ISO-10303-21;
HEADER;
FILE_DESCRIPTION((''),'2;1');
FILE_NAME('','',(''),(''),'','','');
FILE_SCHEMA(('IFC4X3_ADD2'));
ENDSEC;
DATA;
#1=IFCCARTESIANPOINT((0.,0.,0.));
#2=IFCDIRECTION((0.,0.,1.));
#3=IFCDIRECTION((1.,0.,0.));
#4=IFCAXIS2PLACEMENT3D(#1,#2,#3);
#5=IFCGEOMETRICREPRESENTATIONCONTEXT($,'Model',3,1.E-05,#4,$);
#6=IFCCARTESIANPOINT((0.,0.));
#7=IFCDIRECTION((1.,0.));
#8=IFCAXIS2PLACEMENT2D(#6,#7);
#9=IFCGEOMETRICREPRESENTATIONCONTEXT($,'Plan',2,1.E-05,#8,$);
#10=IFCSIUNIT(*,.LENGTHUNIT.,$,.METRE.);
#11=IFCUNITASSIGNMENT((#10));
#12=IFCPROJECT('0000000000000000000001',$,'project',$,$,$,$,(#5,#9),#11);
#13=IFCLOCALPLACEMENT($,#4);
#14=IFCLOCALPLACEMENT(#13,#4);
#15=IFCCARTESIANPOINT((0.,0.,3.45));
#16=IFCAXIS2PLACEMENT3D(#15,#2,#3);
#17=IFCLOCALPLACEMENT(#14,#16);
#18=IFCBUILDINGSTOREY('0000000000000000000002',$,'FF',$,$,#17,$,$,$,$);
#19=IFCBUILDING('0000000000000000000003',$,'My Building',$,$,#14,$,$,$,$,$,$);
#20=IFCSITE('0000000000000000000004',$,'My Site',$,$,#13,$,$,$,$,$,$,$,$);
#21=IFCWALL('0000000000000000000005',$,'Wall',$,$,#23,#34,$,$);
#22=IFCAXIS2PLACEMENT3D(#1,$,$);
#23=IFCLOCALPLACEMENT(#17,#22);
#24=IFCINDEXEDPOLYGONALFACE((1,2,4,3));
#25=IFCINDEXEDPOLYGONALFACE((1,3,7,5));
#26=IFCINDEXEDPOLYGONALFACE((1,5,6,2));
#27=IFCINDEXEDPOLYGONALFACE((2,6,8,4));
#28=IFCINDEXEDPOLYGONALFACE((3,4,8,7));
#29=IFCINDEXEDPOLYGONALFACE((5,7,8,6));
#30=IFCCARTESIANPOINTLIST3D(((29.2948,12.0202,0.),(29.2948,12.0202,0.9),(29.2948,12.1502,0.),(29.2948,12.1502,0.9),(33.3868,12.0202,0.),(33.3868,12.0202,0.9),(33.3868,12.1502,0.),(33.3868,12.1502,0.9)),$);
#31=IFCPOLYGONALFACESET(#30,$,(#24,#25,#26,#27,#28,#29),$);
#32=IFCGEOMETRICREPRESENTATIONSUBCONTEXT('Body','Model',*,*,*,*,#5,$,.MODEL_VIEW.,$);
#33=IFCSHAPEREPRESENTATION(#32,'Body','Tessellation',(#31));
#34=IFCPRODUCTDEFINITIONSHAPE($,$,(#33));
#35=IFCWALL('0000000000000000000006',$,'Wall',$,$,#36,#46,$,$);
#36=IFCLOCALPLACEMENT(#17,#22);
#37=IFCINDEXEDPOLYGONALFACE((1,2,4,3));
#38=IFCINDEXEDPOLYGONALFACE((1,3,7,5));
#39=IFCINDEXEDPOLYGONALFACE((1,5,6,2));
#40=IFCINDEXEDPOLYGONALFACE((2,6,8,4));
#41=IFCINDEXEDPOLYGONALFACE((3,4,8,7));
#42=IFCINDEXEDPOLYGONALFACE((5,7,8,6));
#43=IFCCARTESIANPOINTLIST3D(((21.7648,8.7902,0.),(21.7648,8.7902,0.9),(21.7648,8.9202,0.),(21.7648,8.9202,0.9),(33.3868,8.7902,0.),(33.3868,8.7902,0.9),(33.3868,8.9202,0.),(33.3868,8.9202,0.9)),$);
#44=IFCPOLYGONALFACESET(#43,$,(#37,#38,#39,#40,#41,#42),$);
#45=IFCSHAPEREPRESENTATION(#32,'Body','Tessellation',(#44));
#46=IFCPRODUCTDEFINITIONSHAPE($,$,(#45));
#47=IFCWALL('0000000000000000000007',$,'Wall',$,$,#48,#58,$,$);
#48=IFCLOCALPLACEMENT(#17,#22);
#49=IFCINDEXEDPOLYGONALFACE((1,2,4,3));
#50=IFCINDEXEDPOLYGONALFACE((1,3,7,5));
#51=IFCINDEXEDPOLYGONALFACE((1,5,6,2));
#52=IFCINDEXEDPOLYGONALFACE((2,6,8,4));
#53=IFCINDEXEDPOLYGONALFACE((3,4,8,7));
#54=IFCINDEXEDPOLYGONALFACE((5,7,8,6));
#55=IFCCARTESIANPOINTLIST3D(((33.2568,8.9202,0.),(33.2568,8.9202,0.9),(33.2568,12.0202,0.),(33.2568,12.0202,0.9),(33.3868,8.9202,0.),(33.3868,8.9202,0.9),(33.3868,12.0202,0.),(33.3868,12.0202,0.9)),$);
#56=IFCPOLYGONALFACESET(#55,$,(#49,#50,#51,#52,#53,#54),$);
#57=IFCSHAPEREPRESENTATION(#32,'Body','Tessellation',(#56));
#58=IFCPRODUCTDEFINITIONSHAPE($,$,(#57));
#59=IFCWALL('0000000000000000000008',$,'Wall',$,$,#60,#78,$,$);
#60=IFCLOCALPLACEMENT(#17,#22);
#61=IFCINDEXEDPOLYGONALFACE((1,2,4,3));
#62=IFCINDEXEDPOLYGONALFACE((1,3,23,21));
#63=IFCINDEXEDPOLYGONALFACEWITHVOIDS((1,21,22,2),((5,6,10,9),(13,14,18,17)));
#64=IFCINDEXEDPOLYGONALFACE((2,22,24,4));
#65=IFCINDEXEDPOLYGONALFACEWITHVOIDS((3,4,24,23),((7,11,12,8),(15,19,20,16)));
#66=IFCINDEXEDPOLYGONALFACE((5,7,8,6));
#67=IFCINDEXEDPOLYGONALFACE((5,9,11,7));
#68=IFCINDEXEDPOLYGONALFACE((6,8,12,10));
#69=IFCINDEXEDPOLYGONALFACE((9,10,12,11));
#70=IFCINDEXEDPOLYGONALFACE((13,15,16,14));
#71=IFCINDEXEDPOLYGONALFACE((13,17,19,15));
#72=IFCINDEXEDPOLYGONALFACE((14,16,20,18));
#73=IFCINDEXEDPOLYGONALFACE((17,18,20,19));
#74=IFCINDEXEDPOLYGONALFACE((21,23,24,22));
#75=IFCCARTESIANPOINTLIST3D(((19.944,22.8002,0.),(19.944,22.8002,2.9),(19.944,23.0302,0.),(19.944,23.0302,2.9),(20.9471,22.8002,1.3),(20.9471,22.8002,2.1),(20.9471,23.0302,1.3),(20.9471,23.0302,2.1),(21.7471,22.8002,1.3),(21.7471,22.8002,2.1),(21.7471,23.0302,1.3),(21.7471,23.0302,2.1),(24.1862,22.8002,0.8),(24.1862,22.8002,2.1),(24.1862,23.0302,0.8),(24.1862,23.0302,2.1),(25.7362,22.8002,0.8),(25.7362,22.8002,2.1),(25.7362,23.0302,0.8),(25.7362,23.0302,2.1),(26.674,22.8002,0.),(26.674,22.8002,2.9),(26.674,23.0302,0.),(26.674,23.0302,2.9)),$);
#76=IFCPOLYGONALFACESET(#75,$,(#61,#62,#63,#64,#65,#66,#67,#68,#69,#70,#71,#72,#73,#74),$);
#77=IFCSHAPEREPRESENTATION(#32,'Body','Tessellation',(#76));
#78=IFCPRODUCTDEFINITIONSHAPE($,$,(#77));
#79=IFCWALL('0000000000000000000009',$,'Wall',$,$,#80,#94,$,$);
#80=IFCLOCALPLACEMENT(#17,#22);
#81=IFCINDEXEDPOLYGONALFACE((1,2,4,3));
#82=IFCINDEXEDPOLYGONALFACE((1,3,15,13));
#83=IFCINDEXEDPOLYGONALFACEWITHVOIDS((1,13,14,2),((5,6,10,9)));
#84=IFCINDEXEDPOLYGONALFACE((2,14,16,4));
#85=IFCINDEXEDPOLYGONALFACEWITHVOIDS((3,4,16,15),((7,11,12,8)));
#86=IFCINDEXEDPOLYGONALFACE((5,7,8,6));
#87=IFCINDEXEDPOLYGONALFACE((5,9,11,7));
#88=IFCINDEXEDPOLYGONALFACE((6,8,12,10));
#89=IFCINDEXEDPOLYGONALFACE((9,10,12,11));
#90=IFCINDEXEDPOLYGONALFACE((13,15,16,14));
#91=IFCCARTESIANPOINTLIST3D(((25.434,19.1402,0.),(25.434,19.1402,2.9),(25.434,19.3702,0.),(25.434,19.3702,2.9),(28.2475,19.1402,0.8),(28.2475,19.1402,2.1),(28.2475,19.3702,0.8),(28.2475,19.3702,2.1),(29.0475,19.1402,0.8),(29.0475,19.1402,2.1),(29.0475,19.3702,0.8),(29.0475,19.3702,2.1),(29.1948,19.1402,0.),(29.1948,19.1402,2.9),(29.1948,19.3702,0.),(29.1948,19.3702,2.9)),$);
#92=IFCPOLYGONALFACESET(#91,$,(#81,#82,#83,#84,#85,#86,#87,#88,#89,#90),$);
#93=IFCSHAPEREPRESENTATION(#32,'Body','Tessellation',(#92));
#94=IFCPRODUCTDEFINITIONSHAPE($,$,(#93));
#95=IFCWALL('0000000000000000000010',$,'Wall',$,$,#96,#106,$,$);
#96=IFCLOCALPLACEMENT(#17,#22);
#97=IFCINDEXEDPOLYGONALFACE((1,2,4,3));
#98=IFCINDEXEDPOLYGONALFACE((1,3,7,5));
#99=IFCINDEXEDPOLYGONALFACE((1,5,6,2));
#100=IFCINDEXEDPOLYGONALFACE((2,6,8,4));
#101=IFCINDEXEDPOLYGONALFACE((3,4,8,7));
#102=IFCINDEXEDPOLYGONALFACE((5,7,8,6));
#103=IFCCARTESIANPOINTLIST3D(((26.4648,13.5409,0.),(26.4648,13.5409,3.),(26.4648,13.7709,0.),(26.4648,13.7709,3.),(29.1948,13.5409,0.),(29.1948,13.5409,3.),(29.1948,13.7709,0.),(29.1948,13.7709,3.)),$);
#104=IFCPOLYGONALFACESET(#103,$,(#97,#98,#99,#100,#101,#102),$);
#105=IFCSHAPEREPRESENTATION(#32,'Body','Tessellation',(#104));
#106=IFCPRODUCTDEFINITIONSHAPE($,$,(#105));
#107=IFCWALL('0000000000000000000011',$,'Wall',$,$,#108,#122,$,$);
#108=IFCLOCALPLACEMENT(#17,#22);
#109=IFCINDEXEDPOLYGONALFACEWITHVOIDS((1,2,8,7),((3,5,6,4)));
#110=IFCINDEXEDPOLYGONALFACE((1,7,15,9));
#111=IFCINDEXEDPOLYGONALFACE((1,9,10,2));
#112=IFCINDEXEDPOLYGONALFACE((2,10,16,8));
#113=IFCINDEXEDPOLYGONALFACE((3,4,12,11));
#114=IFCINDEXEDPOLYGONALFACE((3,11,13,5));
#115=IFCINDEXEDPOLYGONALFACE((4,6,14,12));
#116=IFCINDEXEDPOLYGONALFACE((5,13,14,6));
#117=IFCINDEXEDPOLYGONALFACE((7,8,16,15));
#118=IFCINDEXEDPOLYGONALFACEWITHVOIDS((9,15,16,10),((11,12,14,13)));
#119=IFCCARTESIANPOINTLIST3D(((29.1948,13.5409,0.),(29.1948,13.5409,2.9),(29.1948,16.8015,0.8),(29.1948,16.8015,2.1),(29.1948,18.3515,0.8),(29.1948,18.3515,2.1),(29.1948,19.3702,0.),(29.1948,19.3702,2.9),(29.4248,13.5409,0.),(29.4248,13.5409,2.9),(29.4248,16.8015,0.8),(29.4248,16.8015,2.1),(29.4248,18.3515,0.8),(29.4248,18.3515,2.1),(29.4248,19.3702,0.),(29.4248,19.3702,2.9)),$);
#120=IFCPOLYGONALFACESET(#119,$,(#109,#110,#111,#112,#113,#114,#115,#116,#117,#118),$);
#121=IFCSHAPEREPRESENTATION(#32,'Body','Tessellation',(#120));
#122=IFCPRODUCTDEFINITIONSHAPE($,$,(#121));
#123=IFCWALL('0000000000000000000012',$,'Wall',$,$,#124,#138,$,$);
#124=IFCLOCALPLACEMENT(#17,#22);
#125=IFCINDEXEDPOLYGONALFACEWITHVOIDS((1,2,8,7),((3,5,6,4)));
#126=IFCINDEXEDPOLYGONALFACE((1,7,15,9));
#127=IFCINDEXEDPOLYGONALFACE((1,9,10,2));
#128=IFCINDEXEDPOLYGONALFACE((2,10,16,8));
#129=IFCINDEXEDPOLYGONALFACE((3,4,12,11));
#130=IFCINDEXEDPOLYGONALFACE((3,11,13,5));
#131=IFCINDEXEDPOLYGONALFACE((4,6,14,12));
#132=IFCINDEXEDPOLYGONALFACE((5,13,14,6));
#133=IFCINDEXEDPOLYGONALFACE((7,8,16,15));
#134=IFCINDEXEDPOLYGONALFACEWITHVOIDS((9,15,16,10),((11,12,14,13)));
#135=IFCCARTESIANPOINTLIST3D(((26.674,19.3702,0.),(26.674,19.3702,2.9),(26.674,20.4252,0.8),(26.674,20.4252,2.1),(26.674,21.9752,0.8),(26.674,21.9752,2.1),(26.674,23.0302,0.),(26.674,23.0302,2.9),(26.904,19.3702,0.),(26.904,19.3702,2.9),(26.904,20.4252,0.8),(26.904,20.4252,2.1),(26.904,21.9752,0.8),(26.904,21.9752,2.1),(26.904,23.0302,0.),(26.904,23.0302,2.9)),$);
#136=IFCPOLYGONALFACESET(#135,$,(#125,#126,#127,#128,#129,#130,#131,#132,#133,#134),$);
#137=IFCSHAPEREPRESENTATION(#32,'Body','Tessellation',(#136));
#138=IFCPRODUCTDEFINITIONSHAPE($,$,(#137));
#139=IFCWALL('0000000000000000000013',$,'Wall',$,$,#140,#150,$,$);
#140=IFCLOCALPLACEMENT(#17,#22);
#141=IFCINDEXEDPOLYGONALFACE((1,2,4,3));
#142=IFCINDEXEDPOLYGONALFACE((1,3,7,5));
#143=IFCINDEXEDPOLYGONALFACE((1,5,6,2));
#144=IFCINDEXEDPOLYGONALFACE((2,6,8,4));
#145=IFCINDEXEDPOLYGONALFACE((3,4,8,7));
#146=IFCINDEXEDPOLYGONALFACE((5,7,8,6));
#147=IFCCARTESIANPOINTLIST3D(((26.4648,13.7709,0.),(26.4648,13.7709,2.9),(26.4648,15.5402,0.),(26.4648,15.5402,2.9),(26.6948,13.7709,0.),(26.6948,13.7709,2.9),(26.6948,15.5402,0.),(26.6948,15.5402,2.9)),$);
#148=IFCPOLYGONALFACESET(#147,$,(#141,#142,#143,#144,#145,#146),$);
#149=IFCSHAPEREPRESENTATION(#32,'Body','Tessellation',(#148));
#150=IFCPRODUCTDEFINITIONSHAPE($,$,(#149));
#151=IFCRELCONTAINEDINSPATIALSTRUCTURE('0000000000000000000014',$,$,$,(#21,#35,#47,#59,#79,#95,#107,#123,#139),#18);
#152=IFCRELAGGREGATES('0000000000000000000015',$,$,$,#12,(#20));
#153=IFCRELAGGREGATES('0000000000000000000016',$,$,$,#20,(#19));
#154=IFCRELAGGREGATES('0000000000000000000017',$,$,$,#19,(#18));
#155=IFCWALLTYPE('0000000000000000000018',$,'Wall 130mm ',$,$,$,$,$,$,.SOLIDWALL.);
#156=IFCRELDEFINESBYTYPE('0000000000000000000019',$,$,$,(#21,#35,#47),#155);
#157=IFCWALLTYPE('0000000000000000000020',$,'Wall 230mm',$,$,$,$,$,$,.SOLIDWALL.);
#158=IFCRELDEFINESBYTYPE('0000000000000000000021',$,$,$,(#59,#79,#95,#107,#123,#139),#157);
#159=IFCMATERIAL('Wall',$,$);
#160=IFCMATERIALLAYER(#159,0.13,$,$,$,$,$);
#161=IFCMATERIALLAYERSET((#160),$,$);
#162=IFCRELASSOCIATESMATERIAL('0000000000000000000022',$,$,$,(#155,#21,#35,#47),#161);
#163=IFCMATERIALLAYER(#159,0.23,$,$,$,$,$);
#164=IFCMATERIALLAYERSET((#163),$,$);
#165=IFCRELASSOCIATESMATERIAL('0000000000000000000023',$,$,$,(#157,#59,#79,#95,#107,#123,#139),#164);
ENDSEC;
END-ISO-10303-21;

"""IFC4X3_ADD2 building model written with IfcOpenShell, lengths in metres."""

from ifc_helpers import new_model, si_unit, frame, origin_with_axes, origin_2d_with_axis, place, context, subcontext, project, spatial, line, indexed_curve, outline, extrude, source, transform, mapped, material, layer, layer_set, layer_usage, type_object, element, save


model = new_model("IFC4X3_ADD2")

# Units and contexts
model_context = context("Model", 3, precision=1e-05, world=origin_with_axes())
plan_context = context("Plan", 2, precision=1e-05, world=origin_2d_with_axis())
body_context_1 = subcontext(model_context, "Body", "Model", "MODEL_VIEW")
ifc_project = project(units=[si_unit("LENGTHUNIT", "METRE")], contexts=[model_context, plan_context])

# Site, building, storey
site_placement = place(None, origin_with_axes())
site = spatial("IfcSite", under=ifc_project, at=site_placement, Name="My Site")
building_placement = place(site_placement, origin_with_axes())
building = spatial("IfcBuilding", under=site, at=building_placement, Name="My Building")
storey_placement = place(building_placement, frame((0.0, 0.0, 3.45), z_axis=(0.0, 0.0, 1.0), x_axis=(1.0, 0.0, 0.0)))
storey = spatial("IfcBuildingStorey", under=building, at=storey_placement, Name="FF")

# Walls
ifc_material_1 = material(Name="Wall")
ifc_layer_1 = layer(ifc_material_1, 0.13)
ifc_layer_set_1 = layer_set([ifc_layer_1])
ifc_layer_usage_1 = layer_usage(ifc_layer_set_1, "AXIS2", "POSITIVE", 0.0)
wall_type_1 = type_object("IfcWallType", Name="Wall 130mm ", PredefinedType="SOLIDWALL", material=ifc_layer_set_1)
wall_1_placement = place(storey_placement, frame((33.3868, 12.1502, 0.0), z_axis=(0.0, 0.0, 1.0), x_axis=(-1.0, 0.0, 0.0)))
element("IfcWall", 1, at=wall_1_placement, inside=storey, type_object=wall_type_1, material=ifc_layer_usage_1, Name="Wall", context=body_context_1, shape_type="SweptSolid", body=[
    extrude(outline(indexed_curve([(0.0, 0.0), (0.0, 0.13), (4.092, 0.13), (4.092, 0.0), (0.0, 0.0)], self_intersect=False)), origin_with_axes(), (0.0, 0.0, 1.0), 0.9),
])
ifc_layer_usage_2 = layer_usage(ifc_layer_set_1, "AXIS2", "POSITIVE", 0.0)
wall_2_placement = place(storey_placement, frame((33.3868, 8.9202, 0.0), z_axis=(0.0, 0.0, 1.0), x_axis=(-1.0, 0.0, 0.0)))
element("IfcWall", 2, at=wall_2_placement, inside=storey, type_object=wall_type_1, material=ifc_layer_usage_2, Name="Wall", context=body_context_1, shape_type="SweptSolid", body=[
    extrude(outline(indexed_curve([(0.0, 0.0), (0.0, 0.13), (11.622, 0.13), (11.622, 0.0), (0.0, 0.0)], self_intersect=False)), origin_with_axes(), (0.0, 0.0, 1.0), 0.9),
])
ifc_layer_usage_3 = layer_usage(ifc_layer_set_1, "AXIS2", "POSITIVE", 0.0)
wall_3_placement = place(storey_placement, frame((33.2568, 12.0202, 0.0), z_axis=(0.0, 0.0, 1.0), x_axis=(0.0, -1.0, 0.0)))
element("IfcWall", 3, at=wall_3_placement, inside=storey, type_object=wall_type_1, material=ifc_layer_usage_3, Name="Wall", context=body_context_1, shape_type="SweptSolid", body=[
    extrude(outline(indexed_curve([(0.0, 0.0), (0.0, 0.13), (3.1, 0.13), (3.1, 0.0), (0.0, 0.0)], self_intersect=False)), origin_with_axes(), (0.0, 0.0, 1.0), 0.9),
])

# Wall, openings
ifc_layer_2 = layer(ifc_material_1, 0.23)
ifc_layer_set_2 = layer_set([ifc_layer_2])
ifc_layer_usage_4 = layer_usage(ifc_layer_set_2, "AXIS2", "POSITIVE", 0.0)
wall_type_2 = type_object("IfcWallType", Name="Wall 230mm", PredefinedType="SOLIDWALL", material=ifc_layer_set_2)
wall_4_placement = place(storey_placement, frame((26.674, 23.0302, 0.0), z_axis=(0.0, 0.0, 1.0), x_axis=(-1.0, 0.0, 0.0)))
wall_4 = element("IfcWall", 4, at=wall_4_placement, inside=storey, type_object=wall_type_2, material=ifc_layer_usage_4, Name="Wall", context=body_context_1, shape_type="SweptSolid", body=[
    extrude(outline(indexed_curve([(0.0, 0.0), (0.0, 0.23), (6.73, 0.23), (6.73, 0.0), (0.0, 0.0)], self_intersect=False)), origin_with_axes(), (0.0, 0.0, 1.0), 2.9),
])
shared_shape_1 = source(origin_with_axes(), body_context_1, "Body", "SweptSolid", [
    extrude(outline(indexed_curve([(0.0, 0.0), (1.55, 0.0), (1.55, 1.3), (0.0, 1.3)], segments=[line(1, 2, 3, 4, 1)])), frame((-0.775, -0.6, 0.0), z_axis=(0.0, -1.0, 0.0), x_axis=(1.0, 0.0, 0.0)), (0.0, 0.0, -1.0), 1.2),
])
opening_1_placement = place(wall_4_placement, frame((1.7127, 0.0, 0.8), z_axis=(0.0, 0.0, 1.0), x_axis=(1.0, 0.0, 0.0)))
element("IfcOpeningElement", 5, at=opening_1_placement, cuts=wall_4, PredefinedType="OPENING", context=body_context_1, shape_type="MappedRepresentation", body=[
    mapped(shared_shape_1, transform((0.0, 0.0, 0.0), x_axis=(1.0, 0.0, 0.0), y_axis=(0.0, 1.0, 0.0), z_axis=(0.0, 0.0, 1.0), scale=1.0)),
])
shared_shape_2 = source(origin_with_axes(), body_context_1, "Body", "SweptSolid", [
    extrude(outline(indexed_curve([(0.0, 0.0), (0.8, 0.0), (0.8, 0.8), (0.0, 0.8)], segments=[line(1, 2, 3, 4, 1)])), frame((-0.4, -0.6, 0.0), z_axis=(0.0, -1.0, 0.0), x_axis=(1.0, 0.0, 0.0)), (0.0, 0.0, -1.0), 1.2),
])
opening_2_placement = place(wall_4_placement, frame((5.3269, 0.0, 1.3), z_axis=(0.0, 0.0, 1.0), x_axis=(1.0, 0.0, 0.0)))
element("IfcOpeningElement", 6, at=opening_2_placement, cuts=wall_4, PredefinedType="OPENING", context=body_context_1, shape_type="MappedRepresentation", body=[
    mapped(shared_shape_2, transform((0.0, 0.0, 0.0), x_axis=(1.0, 0.0, 0.0), y_axis=(0.0, 1.0, 0.0), z_axis=(0.0, 0.0, 1.0), scale=1.0)),
])

# Wall, opening
ifc_layer_usage_5 = layer_usage(ifc_layer_set_2, "AXIS2", "POSITIVE", 0.0)
wall_5_placement = place(storey_placement, frame((29.1948, 19.3702, 0.0), z_axis=(0.0, 0.0, 1.0), x_axis=(-1.0, 0.0, 0.0)))
wall_5 = element("IfcWall", 7, at=wall_5_placement, inside=storey, type_object=wall_type_2, material=ifc_layer_usage_5, Name="Wall", context=body_context_1, shape_type="SweptSolid", body=[
    extrude(outline(indexed_curve([(0.0, 0.0), (0.0, 0.23), (3.7608, 0.23), (3.7608, 0.0), (0.0, 0.0)], self_intersect=False)), origin_with_axes(), (0.0, 0.0, 1.0), 2.9),
])
shared_shape_3 = source(origin_with_axes(), body_context_1, "Body", "SweptSolid", [
    extrude(outline(indexed_curve([(0.0, 0.0), (0.8, 0.0), (0.8, 1.3), (0.0, 1.3)], segments=[line(1, 2, 3, 4, 1)])), frame((-0.4, -0.6, 0.0), z_axis=(0.0, -1.0, 0.0), x_axis=(1.0, 0.0, 0.0)), (0.0, 0.0, -1.0), 1.2),
])
opening_3_placement = place(wall_5_placement, frame((0.5473, 0.0, 0.8), z_axis=(0.0, 0.0, 1.0), x_axis=(1.0, 0.0, 0.0)))
element("IfcOpeningElement", 8, at=opening_3_placement, cuts=wall_5, PredefinedType="OPENING", context=body_context_1, shape_type="MappedRepresentation", body=[
    mapped(shared_shape_3, transform((0.0, 0.0, 0.0), x_axis=(1.0, 0.0, 0.0), y_axis=(0.0, 1.0, 0.0), z_axis=(0.0, 0.0, 1.0), scale=1.0)),
])

# Wall
ifc_layer_usage_6 = layer_usage(ifc_layer_set_2, "AXIS2", "POSITIVE", 0.0)
wall_6_placement = place(storey_placement, frame((29.1948, 13.7709, 0.0), z_axis=(0.0, 0.0, 1.0), x_axis=(-1.0, 0.0, 0.0)))
element("IfcWall", 9, at=wall_6_placement, inside=storey, type_object=wall_type_2, material=ifc_layer_usage_6, Name="Wall", context=body_context_1, shape_type="SweptSolid", body=[
    extrude(outline(indexed_curve([(0.0, 0.0), (0.0, 0.23), (2.73, 0.23), (2.73, 0.0), (0.0, 0.0)], self_intersect=False)), origin_with_axes(), (0.0, 0.0, 1.0), 3.0),
])

# Walls, openings
ifc_layer_usage_7 = layer_usage(ifc_layer_set_2, "AXIS2", "POSITIVE", 0.0)
wall_7_placement = place(storey_placement, frame((29.4248, 13.5409, 0.0), z_axis=(0.0, 0.0, 1.0), x_axis=(0.000001, 1.0, 0.0)))
wall_7 = element("IfcWall", 10, at=wall_7_placement, inside=storey, type_object=wall_type_2, material=ifc_layer_usage_7, Name="Wall", context=body_context_1, shape_type="SweptSolid", body=[
    extrude(outline(indexed_curve([(0.0, 0.0), (0.0, 0.23), (5.8293, 0.23), (5.8293, 0.0), (0.0, 0.0)], self_intersect=False)), origin_with_axes(), (0.0, 0.0, 1.0), 2.9),
])
opening_4_placement = place(wall_7_placement, frame((4.0356, 0.0, 0.8), z_axis=(0.0, 0.0, 1.0), x_axis=(1.0, 0.0, 0.0)))
element("IfcOpeningElement", 11, at=opening_4_placement, cuts=wall_7, PredefinedType="OPENING", context=body_context_1, shape_type="MappedRepresentation", body=[
    mapped(shared_shape_1, transform((0.0, 0.0, 0.0), x_axis=(1.0, 0.0, 0.0), y_axis=(0.0, 1.0, 0.0), z_axis=(0.0, 0.0, 1.0), scale=1.0)),
])
ifc_layer_usage_8 = layer_usage(ifc_layer_set_2, "AXIS2", "POSITIVE", 0.0)
wall_8_placement = place(storey_placement, frame((26.904, 19.3702, 0.0), z_axis=(0.0, 0.0, 1.0), x_axis=(0.000001, 1.0, 0.0)))
wall_8 = element("IfcWall", 12, at=wall_8_placement, inside=storey, type_object=wall_type_2, material=ifc_layer_usage_8, Name="Wall", context=body_context_1, shape_type="SweptSolid", body=[
    extrude(outline(indexed_curve([(0.0, 0.0), (0.0, 0.23), (3.66, 0.23), (3.66, 0.0), (0.0, 0.0)], self_intersect=False)), origin_with_axes(), (0.0, 0.0, 1.0), 2.9),
])
opening_5_placement = place(wall_8_placement, frame((1.83, 0.0, 0.8), z_axis=(0.0, 0.0, 1.0), x_axis=(1.0, 0.0, 0.0)))
element("IfcOpeningElement", 13, at=opening_5_placement, cuts=wall_8, PredefinedType="OPENING", context=body_context_1, shape_type="MappedRepresentation", body=[
    mapped(shared_shape_1, transform((0.0, 0.0, 0.0), x_axis=(1.0, 0.0, 0.0), y_axis=(0.0, 1.0, 0.0), z_axis=(0.0, 0.0, 1.0), scale=1.0)),
])

# Wall
ifc_layer_usage_9 = layer_usage(ifc_layer_set_2, "AXIS2", "POSITIVE", 0.0)
wall_9_placement = place(storey_placement, frame((26.6948, 13.7709, 0.0), z_axis=(0.0, 0.0, 1.0), x_axis=(0.000001, 1.0, 0.0)))
element("IfcWall", 14, at=wall_9_placement, inside=storey, type_object=wall_type_2, material=ifc_layer_usage_9, Name="Wall", context=body_context_1, shape_type="SweptSolid", body=[
    extrude(outline(indexed_curve([(0.0, 0.0), (0.0, 0.23), (1.7693, 0.23), (1.7693, 0.0), (0.0, 0.0)], self_intersect=False)), origin_with_axes(), (0.0, 0.0, 1.0), 2.9),
])

save(model, "model.ifc")
